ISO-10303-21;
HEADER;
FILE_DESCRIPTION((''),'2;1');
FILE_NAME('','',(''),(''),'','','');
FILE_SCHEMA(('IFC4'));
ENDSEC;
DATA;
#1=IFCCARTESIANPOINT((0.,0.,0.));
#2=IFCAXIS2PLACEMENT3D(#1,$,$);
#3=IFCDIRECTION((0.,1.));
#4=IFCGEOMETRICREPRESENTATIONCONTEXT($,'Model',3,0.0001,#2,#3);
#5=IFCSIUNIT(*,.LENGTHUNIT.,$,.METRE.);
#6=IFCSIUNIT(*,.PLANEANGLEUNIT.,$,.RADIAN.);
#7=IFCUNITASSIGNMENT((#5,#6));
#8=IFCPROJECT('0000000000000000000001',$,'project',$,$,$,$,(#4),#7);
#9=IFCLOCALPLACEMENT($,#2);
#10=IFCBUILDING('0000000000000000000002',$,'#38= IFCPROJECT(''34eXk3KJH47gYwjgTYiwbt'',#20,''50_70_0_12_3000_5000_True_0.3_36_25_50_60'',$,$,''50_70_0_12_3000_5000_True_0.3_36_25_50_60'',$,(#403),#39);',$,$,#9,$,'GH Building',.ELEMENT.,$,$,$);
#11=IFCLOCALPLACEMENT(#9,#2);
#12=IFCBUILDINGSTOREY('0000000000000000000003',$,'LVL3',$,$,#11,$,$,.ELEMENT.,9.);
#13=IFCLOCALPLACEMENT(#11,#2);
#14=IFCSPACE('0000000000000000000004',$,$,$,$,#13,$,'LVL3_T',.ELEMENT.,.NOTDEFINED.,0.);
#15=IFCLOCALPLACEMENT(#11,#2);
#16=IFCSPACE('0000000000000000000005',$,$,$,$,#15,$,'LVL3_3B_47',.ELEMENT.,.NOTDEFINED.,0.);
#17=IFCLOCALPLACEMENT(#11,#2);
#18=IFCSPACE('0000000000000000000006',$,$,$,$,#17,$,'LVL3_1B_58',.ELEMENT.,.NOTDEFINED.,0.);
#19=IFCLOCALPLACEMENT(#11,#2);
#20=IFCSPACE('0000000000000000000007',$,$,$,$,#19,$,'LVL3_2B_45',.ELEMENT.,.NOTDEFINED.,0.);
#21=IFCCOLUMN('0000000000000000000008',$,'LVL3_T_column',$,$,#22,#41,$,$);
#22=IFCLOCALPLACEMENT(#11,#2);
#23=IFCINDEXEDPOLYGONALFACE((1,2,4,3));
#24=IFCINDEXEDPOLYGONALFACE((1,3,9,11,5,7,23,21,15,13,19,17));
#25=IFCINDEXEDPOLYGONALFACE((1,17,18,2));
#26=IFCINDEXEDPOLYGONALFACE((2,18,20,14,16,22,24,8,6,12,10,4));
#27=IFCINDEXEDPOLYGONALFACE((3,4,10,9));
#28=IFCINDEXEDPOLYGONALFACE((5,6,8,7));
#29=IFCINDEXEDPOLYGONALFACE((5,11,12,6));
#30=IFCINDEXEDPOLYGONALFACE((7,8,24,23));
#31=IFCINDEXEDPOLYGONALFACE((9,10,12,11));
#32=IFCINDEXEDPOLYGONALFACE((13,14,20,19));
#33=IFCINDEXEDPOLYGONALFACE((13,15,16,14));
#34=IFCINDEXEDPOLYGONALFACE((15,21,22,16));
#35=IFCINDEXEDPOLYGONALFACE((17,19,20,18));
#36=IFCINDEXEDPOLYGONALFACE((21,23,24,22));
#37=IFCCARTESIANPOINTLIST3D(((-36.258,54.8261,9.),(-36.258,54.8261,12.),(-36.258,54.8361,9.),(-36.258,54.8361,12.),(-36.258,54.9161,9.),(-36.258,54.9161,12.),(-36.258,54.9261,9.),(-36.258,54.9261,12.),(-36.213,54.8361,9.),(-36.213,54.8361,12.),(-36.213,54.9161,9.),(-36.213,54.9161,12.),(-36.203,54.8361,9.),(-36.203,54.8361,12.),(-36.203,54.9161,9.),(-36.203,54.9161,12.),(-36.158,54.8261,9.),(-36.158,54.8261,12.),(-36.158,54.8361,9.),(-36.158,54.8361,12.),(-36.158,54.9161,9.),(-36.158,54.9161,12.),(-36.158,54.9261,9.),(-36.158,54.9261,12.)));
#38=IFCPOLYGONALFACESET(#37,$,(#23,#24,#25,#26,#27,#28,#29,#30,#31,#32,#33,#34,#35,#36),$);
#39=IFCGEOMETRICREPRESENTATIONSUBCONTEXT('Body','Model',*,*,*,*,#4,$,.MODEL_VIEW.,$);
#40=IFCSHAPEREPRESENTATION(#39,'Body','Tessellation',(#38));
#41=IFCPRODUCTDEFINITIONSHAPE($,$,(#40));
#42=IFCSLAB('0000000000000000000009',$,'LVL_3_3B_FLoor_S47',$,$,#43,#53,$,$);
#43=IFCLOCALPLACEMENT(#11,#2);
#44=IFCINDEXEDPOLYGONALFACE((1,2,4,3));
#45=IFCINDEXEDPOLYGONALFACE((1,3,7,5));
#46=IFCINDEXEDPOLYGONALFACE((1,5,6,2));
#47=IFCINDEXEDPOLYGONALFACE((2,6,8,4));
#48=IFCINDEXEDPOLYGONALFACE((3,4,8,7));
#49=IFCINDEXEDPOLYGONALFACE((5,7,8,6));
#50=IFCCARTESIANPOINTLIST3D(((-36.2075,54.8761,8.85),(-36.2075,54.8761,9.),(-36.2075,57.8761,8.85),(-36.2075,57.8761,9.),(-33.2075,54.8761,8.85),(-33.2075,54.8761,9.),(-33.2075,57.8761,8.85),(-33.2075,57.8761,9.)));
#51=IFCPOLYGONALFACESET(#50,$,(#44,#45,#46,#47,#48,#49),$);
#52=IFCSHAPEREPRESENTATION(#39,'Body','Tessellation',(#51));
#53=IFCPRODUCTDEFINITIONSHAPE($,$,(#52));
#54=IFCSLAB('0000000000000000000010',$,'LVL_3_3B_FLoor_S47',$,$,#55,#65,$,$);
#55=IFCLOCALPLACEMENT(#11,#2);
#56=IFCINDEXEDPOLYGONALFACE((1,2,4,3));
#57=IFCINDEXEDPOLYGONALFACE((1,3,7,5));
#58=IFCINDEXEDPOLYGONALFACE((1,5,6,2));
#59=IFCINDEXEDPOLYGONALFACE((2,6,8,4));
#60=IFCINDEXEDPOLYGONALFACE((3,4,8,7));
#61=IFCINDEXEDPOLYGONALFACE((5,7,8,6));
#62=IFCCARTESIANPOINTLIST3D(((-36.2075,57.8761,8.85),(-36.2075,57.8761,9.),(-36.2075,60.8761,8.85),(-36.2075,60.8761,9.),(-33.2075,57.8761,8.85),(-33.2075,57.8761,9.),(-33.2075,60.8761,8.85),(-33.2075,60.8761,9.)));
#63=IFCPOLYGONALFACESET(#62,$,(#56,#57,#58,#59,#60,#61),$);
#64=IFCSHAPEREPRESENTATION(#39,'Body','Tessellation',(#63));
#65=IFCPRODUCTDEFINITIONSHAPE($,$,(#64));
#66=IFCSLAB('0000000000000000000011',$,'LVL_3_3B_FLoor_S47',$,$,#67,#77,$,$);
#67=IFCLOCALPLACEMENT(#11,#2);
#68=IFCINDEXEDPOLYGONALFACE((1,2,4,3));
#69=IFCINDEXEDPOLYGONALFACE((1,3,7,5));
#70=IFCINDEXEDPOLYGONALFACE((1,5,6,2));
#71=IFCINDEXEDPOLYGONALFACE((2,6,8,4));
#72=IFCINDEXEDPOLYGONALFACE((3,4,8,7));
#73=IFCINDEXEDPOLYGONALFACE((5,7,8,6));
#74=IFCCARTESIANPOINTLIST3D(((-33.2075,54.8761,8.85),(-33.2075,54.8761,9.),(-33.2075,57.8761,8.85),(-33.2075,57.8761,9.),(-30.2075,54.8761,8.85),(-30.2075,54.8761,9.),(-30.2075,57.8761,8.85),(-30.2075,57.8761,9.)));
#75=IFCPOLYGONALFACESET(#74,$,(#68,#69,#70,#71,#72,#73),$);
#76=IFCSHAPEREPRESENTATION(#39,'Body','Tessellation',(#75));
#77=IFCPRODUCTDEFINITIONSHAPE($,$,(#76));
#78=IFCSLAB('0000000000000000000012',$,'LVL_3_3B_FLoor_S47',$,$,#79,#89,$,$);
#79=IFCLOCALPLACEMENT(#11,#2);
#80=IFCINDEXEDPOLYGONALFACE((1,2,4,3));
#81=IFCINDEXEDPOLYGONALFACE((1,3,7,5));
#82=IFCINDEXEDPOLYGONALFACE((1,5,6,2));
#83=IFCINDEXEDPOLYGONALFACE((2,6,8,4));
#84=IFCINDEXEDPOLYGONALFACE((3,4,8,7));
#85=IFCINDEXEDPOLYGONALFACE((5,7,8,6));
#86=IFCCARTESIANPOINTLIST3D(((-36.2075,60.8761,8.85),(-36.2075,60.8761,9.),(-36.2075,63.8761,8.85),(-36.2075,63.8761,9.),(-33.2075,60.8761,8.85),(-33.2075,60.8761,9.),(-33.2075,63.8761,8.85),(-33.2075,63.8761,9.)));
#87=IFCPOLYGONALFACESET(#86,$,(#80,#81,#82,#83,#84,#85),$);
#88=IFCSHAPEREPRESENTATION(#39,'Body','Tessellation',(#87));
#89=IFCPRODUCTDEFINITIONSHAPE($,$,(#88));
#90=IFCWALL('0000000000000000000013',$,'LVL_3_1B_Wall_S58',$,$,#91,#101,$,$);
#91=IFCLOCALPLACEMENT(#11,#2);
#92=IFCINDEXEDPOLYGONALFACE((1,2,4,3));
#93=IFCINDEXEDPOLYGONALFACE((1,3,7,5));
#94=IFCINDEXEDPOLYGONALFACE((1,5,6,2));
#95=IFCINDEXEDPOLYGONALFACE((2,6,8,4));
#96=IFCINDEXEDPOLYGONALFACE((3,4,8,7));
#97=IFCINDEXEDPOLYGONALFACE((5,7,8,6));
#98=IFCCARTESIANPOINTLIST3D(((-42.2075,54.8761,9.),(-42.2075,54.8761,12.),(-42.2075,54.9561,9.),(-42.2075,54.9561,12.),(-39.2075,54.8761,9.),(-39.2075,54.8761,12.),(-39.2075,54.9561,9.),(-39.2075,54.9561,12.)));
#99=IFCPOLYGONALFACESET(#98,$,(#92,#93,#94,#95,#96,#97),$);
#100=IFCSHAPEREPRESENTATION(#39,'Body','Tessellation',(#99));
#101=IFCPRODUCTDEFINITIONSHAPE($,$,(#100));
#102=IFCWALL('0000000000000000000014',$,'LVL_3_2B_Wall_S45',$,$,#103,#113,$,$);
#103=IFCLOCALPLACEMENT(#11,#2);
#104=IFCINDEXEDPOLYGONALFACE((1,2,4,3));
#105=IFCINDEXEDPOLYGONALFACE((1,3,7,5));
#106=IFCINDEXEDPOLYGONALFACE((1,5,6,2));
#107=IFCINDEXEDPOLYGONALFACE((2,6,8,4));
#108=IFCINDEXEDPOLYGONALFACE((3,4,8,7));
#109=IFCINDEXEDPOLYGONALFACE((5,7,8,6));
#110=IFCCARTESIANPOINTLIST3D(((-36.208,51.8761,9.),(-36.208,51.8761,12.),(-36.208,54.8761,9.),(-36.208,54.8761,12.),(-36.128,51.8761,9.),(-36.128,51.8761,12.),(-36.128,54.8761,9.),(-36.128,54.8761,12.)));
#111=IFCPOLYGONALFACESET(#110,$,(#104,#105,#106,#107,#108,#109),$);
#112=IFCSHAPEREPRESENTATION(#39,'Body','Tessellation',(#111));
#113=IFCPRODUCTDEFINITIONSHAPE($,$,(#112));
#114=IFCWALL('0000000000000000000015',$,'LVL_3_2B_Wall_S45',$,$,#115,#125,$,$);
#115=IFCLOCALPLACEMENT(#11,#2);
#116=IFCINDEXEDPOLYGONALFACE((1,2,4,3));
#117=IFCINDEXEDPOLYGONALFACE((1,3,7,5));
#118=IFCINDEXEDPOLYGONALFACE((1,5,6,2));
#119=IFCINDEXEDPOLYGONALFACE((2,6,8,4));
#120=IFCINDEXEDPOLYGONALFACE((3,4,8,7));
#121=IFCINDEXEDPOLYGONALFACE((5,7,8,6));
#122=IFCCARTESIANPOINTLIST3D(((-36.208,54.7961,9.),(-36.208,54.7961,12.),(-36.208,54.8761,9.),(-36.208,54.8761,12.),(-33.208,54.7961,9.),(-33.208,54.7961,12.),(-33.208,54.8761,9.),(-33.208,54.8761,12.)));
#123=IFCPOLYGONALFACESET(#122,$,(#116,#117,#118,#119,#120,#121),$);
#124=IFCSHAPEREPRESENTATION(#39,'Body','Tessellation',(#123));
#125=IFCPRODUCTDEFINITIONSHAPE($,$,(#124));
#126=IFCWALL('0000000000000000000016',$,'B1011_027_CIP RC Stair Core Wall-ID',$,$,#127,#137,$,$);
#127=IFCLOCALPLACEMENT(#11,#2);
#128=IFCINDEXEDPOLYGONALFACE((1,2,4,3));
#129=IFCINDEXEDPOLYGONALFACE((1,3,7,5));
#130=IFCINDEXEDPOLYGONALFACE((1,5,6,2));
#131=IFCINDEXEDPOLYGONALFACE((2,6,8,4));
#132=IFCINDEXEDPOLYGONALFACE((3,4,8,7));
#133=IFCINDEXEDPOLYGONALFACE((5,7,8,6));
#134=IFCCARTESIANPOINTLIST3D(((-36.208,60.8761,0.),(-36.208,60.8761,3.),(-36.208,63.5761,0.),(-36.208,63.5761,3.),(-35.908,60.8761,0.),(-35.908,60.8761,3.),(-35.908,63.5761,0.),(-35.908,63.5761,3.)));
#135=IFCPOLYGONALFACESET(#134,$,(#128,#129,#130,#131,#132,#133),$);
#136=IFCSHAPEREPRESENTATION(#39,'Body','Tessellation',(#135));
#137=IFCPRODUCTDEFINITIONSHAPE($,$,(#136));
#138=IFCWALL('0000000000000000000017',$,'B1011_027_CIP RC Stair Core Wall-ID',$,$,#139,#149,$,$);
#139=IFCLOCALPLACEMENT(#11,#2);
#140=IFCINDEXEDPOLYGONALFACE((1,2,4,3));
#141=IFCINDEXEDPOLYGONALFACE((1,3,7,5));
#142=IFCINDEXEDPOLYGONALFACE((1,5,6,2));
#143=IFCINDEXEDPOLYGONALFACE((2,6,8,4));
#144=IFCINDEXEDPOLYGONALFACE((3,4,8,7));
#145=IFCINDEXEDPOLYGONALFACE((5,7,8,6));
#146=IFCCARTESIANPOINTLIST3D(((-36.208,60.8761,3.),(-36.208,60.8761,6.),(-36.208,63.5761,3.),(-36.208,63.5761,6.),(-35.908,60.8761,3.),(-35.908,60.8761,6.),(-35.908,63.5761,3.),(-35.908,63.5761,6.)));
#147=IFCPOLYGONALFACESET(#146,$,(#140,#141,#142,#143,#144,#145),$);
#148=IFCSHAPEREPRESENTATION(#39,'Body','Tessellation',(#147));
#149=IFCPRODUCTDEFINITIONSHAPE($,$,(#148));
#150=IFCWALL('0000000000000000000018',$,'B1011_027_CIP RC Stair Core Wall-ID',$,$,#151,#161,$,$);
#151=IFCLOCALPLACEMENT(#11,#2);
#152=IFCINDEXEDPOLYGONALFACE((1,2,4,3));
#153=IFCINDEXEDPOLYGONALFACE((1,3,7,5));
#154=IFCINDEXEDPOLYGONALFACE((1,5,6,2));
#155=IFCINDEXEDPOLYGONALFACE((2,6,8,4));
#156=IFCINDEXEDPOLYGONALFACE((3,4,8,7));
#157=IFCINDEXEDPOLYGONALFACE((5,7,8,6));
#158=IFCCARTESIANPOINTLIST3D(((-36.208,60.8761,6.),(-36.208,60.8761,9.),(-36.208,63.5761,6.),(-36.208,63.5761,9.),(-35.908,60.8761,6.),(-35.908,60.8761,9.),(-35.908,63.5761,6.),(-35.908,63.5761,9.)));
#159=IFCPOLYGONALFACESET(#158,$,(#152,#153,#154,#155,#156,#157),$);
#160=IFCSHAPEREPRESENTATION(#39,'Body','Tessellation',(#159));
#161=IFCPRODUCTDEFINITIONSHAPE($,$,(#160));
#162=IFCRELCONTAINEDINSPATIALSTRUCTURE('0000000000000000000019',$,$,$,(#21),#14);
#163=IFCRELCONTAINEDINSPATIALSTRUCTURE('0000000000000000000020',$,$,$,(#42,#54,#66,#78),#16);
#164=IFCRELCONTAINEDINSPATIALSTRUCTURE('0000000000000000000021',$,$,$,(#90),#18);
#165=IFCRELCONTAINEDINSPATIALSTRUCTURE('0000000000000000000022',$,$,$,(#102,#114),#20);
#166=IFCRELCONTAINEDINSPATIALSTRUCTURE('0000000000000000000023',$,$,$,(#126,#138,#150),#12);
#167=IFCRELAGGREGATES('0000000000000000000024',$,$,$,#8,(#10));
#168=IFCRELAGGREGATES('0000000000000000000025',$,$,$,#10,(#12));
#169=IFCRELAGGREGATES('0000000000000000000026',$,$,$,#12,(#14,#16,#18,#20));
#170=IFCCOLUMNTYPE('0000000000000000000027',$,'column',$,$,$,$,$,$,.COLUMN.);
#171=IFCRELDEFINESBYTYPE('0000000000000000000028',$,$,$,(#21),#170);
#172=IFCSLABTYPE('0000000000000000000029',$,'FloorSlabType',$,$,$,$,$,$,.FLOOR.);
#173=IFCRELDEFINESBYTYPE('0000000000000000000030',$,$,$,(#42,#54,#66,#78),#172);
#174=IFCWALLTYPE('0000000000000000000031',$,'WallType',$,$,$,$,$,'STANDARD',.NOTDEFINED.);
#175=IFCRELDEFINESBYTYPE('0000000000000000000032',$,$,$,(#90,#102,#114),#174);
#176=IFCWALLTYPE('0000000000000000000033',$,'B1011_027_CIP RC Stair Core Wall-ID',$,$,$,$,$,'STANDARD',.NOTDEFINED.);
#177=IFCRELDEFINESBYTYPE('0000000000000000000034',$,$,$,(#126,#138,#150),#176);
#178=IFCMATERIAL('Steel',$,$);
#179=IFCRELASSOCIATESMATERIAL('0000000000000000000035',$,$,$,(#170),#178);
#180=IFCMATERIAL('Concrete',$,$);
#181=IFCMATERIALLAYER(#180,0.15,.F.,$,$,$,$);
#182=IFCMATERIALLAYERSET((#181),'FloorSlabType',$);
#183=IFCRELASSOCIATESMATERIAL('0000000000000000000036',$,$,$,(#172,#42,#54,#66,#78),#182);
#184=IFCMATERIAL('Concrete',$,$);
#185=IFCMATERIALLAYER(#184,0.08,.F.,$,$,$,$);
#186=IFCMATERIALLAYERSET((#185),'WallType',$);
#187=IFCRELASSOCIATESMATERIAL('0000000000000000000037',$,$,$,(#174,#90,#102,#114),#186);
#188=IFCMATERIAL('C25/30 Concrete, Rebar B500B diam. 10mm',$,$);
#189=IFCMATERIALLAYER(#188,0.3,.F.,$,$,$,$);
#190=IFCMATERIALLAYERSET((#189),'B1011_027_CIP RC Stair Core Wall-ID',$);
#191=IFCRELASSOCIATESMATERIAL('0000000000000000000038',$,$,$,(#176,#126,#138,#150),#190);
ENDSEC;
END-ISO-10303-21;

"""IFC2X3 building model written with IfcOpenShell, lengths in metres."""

from ifc_helpers import new_model, si_unit, direction, frame, frame_2d, origin, origin_2d, place, context, subcontext, project, spatial, rectangle, i_section, extrude, material, layer, layer_set, layer_usage, type_object, element, save


model = new_model("IFC2X3")

# Units and contexts
model_context = context("Model", 3, precision=0.0001, world=origin(), true_north=direction((0.0, 1.0)))
body_context = subcontext(model_context, "Body", "Model", "MODEL_VIEW")
ifc_project = project(units=[si_unit("LENGTHUNIT", "METRE"), si_unit("PLANEANGLEUNIT", "RADIAN")], contexts=[model_context])

# Building, storey, space
building_placement = place(None, origin())
building = spatial("IfcBuilding", under=ifc_project, at=building_placement, Name="#38= IFCPROJECT('34eXk3KJH47gYwjgTYiwbt',#20,'50_70_0_12_3000_5000_True_0.3_36_25_50_60',$,$,'50_70_0_12_3000_5000_True_0.3_36_25_50_60',$,(#403),#39);", LongName="GH Building", CompositionType="ELEMENT")
storey_placement = place(building_placement, origin())
storey = spatial("IfcBuildingStorey", under=building, at=storey_placement, Name="LVL3", CompositionType="ELEMENT", Elevation=9.0)
space_1_placement = place(storey_placement, origin())
space_1 = spatial("IfcSpace", under=storey, at=space_1_placement, LongName="LVL3_T", CompositionType="ELEMENT", InteriorOrExteriorSpace="NOTDEFINED", ElevationWithFlooring=0.0)

# Column
ifc_material_1 = material(Name="Steel")
column_type = type_object("IfcColumnType", Name="column", PredefinedType="COLUMN", material=ifc_material_1)
for number, where, name in (
    (1, (-36.208, 54.8761, 9.0), "LVL3_T_column"),
):
    element("IfcColumn", number, at=place(space_1_placement, frame(where)), inside=space_1, type_object=column_type, Name=name, context=body_context, shape_type="SweptSolid", body=[
        extrude(i_section(OverallWidth=0.1, OverallDepth=0.1, WebThickness=0.01, FlangeThickness=0.01, at=origin_2d()), origin(), (0.0, 0.0, 1.0), 3.0),
    ])

# Shared definitions
space_2_placement = place(storey_placement, origin())
space_2 = spatial("IfcSpace", under=storey, at=space_2_placement, LongName="LVL3_3B_47", CompositionType="ELEMENT", InteriorOrExteriorSpace="NOTDEFINED", ElevationWithFlooring=0.0)

# Slabs
ifc_material_2 = material(Name="Concrete")
ifc_layer_1 = layer(ifc_material_2, 0.15, ventilated=False)
ifc_layer_set_1 = layer_set([ifc_layer_1], Name="FloorSlabType")
ifc_layer_usage_1 = layer_usage(ifc_layer_set_1, "AXIS3", "NEGATIVE", -0.15)
slab_type = type_object("IfcSlabType", Name="FloorSlabType", PredefinedType="FLOOR", material=ifc_layer_set_1)
slab_1_placement = place(space_2_placement, frame((-33.2075, 54.8761, 8.85), z_axis=(0.0, 0.0, 1.0), x_axis=(0.0, 1.0, 0.0)))
element("IfcSlab", 2, at=slab_1_placement, inside=space_2, type_object=slab_type, material=ifc_layer_usage_1, Name="LVL_3_3B_FLoor_S47", context=body_context, shape_type="SweptSolid", body=[
    extrude(rectangle(XDim=3.0, YDim=3.0, at=frame_2d((1.5, 1.5))), origin(), (0.0, 0.0, 1.0), 0.15),
])
ifc_layer_usage_2 = layer_usage(ifc_layer_set_1, "AXIS3", "NEGATIVE", -0.15)
slab_2_placement = place(space_2_placement, frame((-33.2075, 57.8761, 8.85), z_axis=(0.0, 0.0, 1.0), x_axis=(0.0, 1.0, 0.0)))
element("IfcSlab", 3, at=slab_2_placement, inside=space_2, type_object=slab_type, material=ifc_layer_usage_2, Name="LVL_3_3B_FLoor_S47", context=body_context, shape_type="SweptSolid", body=[
    extrude(rectangle(XDim=3.0, YDim=3.0, at=frame_2d((1.5, 1.5))), origin(), (0.0, 0.0, 1.0), 0.15),
])
ifc_layer_usage_3 = layer_usage(ifc_layer_set_1, "AXIS3", "NEGATIVE", -0.15)
slab_3_placement = place(space_2_placement, frame((-30.2075, 54.8761, 8.85), z_axis=(0.0, 0.0, 1.0), x_axis=(0.0, 1.0, 0.0)))
element("IfcSlab", 4, at=slab_3_placement, inside=space_2, type_object=slab_type, material=ifc_layer_usage_3, Name="LVL_3_3B_FLoor_S47", context=body_context, shape_type="SweptSolid", body=[
    extrude(rectangle(XDim=3.0, YDim=3.0, at=frame_2d((1.5, 1.5))), origin(), (0.0, 0.0, 1.0), 0.15),
])
ifc_layer_usage_4 = layer_usage(ifc_layer_set_1, "AXIS3", "NEGATIVE", -0.15)
slab_4_placement = place(space_2_placement, frame((-33.2075, 60.8761, 8.85), z_axis=(0.0, 0.0, 1.0), x_axis=(0.0, 1.0, 0.0)))
element("IfcSlab", 5, at=slab_4_placement, inside=space_2, type_object=slab_type, material=ifc_layer_usage_4, Name="LVL_3_3B_FLoor_S47", context=body_context, shape_type="SweptSolid", body=[
    extrude(rectangle(XDim=3.0, YDim=3.0, at=frame_2d((1.5, 1.5))), origin(), (0.0, 0.0, 1.0), 0.15),
])

# Shared definitions
space_3_placement = place(storey_placement, origin())
space_3 = spatial("IfcSpace", under=storey, at=space_3_placement, LongName="LVL3_1B_58", CompositionType="ELEMENT", InteriorOrExteriorSpace="NOTDEFINED", ElevationWithFlooring=0.0)

# Wall
ifc_material_3 = material(Name="Concrete")
ifc_layer_2 = layer(ifc_material_3, 0.08, ventilated=False)
ifc_layer_set_2 = layer_set([ifc_layer_2], Name="WallType")
ifc_layer_usage_5 = layer_usage(ifc_layer_set_2, "AXIS2", "NEGATIVE", 0.0)
wall_type_1 = type_object("IfcWallType", Name="WallType", ElementType="STANDARD", PredefinedType="NOTDEFINED", material=ifc_layer_set_2)
wall_1_placement = place(space_3_placement, frame((-39.2075, 54.8761, 9.0), z_axis=(0.0, 0.0, 1.0), x_axis=(-1.0, 0.0, 0.0)))
element("IfcWall", 6, at=wall_1_placement, inside=space_3, type_object=wall_type_1, material=ifc_layer_usage_5, Name="LVL_3_1B_Wall_S58", context=body_context, shape_type="SweptSolid", body=[
    extrude(rectangle(XDim=3.0, YDim=0.08, at=frame_2d((1.5, -0.04))), origin(), (0.0, 0.0, 1.0), 3.0),
])

# Shared definitions
space_4_placement = place(storey_placement, origin())
space_4 = spatial("IfcSpace", under=storey, at=space_4_placement, LongName="LVL3_2B_45", CompositionType="ELEMENT", InteriorOrExteriorSpace="NOTDEFINED", ElevationWithFlooring=0.0)

# Walls
ifc_layer_usage_6 = layer_usage(ifc_layer_set_2, "AXIS2", "NEGATIVE", 0.0)
wall_2_placement = place(space_4_placement, frame((-36.208, 51.8761, 9.0), z_axis=(0.0, 0.0, 1.0), x_axis=(0.0, 1.0, 0.0)))
element("IfcWall", 7, at=wall_2_placement, inside=space_4, type_object=wall_type_1, material=ifc_layer_usage_6, Name="LVL_3_2B_Wall_S45", context=body_context, shape_type="SweptSolid", body=[
    extrude(rectangle(XDim=3.0, YDim=0.08, at=frame_2d((1.5, -0.04))), origin(), (0.0, 0.0, 1.0), 3.0),
])
ifc_layer_usage_7 = layer_usage(ifc_layer_set_2, "AXIS2", "NEGATIVE", 0.0)
wall_3_placement = place(space_4_placement, frame((-36.208, 54.8761, 9.0)))
element("IfcWall", 8, at=wall_3_placement, inside=space_4, type_object=wall_type_1, material=ifc_layer_usage_7, Name="LVL_3_2B_Wall_S45", context=body_context, shape_type="SweptSolid", body=[
    extrude(rectangle(XDim=3.0, YDim=0.08, at=frame_2d((1.5, -0.04))), origin(), (0.0, 0.0, 1.0), 3.0),
])

# Walls
ifc_material_4 = material(Name="C25/30 Concrete, Rebar B500B diam. 10mm")
ifc_layer_3 = layer(ifc_material_4, 0.3, ventilated=False)
ifc_layer_set_3 = layer_set([ifc_layer_3], Name="B1011_027_CIP RC Stair Core Wall-ID")
ifc_layer_usage_8 = layer_usage(ifc_layer_set_3, "AXIS2", "POSITIVE", 0.0)
wall_type_2 = type_object("IfcWallType", Name="B1011_027_CIP RC Stair Core Wall-ID", ElementType="STANDARD", PredefinedType="NOTDEFINED", material=ifc_layer_set_3)
wall_4_placement = place(storey_placement, frame((-36.208, 63.5761, 0.0), z_axis=(0.0, 0.0, 1.0), x_axis=(0.0, -1.0, 0.0)))
element("IfcWall", 9, at=wall_4_placement, inside=storey, type_object=wall_type_2, material=ifc_layer_usage_8, Name="B1011_027_CIP RC Stair Core Wall-ID", context=body_context, shape_type="SweptSolid", body=[
    extrude(rectangle(XDim=2.7, YDim=0.3, at=frame_2d((1.35, 0.15))), origin(), (0.0, 0.0, 1.0), 3.0),
])
ifc_layer_usage_9 = layer_usage(ifc_layer_set_3, "AXIS2", "POSITIVE", 0.0)
wall_5_placement = place(storey_placement, frame((-36.208, 63.5761, 3.0), z_axis=(0.0, 0.0, 1.0), x_axis=(0.0, -1.0, 0.0)))
element("IfcWall", 10, at=wall_5_placement, inside=storey, type_object=wall_type_2, material=ifc_layer_usage_9, Name="B1011_027_CIP RC Stair Core Wall-ID", context=body_context, shape_type="SweptSolid", body=[
    extrude(rectangle(XDim=2.7, YDim=0.3, at=frame_2d((1.35, 0.15))), origin(), (0.0, 0.0, 1.0), 3.0),
])
ifc_layer_usage_10 = layer_usage(ifc_layer_set_3, "AXIS2", "POSITIVE", 0.0)
wall_6_placement = place(storey_placement, frame((-36.208, 63.5761, 6.0), z_axis=(0.0, 0.0, 1.0), x_axis=(0.0, -1.0, 0.0)))
element("IfcWall", 11, at=wall_6_placement, inside=storey, type_object=wall_type_2, material=ifc_layer_usage_10, Name="B1011_027_CIP RC Stair Core Wall-ID", context=body_context, shape_type="SweptSolid", body=[
    extrude(rectangle(XDim=2.7, YDim=0.3, at=frame_2d((1.35, 0.15))), origin(), (0.0, 0.0, 1.0), 3.0),
])

save(model, "model.ifc")
